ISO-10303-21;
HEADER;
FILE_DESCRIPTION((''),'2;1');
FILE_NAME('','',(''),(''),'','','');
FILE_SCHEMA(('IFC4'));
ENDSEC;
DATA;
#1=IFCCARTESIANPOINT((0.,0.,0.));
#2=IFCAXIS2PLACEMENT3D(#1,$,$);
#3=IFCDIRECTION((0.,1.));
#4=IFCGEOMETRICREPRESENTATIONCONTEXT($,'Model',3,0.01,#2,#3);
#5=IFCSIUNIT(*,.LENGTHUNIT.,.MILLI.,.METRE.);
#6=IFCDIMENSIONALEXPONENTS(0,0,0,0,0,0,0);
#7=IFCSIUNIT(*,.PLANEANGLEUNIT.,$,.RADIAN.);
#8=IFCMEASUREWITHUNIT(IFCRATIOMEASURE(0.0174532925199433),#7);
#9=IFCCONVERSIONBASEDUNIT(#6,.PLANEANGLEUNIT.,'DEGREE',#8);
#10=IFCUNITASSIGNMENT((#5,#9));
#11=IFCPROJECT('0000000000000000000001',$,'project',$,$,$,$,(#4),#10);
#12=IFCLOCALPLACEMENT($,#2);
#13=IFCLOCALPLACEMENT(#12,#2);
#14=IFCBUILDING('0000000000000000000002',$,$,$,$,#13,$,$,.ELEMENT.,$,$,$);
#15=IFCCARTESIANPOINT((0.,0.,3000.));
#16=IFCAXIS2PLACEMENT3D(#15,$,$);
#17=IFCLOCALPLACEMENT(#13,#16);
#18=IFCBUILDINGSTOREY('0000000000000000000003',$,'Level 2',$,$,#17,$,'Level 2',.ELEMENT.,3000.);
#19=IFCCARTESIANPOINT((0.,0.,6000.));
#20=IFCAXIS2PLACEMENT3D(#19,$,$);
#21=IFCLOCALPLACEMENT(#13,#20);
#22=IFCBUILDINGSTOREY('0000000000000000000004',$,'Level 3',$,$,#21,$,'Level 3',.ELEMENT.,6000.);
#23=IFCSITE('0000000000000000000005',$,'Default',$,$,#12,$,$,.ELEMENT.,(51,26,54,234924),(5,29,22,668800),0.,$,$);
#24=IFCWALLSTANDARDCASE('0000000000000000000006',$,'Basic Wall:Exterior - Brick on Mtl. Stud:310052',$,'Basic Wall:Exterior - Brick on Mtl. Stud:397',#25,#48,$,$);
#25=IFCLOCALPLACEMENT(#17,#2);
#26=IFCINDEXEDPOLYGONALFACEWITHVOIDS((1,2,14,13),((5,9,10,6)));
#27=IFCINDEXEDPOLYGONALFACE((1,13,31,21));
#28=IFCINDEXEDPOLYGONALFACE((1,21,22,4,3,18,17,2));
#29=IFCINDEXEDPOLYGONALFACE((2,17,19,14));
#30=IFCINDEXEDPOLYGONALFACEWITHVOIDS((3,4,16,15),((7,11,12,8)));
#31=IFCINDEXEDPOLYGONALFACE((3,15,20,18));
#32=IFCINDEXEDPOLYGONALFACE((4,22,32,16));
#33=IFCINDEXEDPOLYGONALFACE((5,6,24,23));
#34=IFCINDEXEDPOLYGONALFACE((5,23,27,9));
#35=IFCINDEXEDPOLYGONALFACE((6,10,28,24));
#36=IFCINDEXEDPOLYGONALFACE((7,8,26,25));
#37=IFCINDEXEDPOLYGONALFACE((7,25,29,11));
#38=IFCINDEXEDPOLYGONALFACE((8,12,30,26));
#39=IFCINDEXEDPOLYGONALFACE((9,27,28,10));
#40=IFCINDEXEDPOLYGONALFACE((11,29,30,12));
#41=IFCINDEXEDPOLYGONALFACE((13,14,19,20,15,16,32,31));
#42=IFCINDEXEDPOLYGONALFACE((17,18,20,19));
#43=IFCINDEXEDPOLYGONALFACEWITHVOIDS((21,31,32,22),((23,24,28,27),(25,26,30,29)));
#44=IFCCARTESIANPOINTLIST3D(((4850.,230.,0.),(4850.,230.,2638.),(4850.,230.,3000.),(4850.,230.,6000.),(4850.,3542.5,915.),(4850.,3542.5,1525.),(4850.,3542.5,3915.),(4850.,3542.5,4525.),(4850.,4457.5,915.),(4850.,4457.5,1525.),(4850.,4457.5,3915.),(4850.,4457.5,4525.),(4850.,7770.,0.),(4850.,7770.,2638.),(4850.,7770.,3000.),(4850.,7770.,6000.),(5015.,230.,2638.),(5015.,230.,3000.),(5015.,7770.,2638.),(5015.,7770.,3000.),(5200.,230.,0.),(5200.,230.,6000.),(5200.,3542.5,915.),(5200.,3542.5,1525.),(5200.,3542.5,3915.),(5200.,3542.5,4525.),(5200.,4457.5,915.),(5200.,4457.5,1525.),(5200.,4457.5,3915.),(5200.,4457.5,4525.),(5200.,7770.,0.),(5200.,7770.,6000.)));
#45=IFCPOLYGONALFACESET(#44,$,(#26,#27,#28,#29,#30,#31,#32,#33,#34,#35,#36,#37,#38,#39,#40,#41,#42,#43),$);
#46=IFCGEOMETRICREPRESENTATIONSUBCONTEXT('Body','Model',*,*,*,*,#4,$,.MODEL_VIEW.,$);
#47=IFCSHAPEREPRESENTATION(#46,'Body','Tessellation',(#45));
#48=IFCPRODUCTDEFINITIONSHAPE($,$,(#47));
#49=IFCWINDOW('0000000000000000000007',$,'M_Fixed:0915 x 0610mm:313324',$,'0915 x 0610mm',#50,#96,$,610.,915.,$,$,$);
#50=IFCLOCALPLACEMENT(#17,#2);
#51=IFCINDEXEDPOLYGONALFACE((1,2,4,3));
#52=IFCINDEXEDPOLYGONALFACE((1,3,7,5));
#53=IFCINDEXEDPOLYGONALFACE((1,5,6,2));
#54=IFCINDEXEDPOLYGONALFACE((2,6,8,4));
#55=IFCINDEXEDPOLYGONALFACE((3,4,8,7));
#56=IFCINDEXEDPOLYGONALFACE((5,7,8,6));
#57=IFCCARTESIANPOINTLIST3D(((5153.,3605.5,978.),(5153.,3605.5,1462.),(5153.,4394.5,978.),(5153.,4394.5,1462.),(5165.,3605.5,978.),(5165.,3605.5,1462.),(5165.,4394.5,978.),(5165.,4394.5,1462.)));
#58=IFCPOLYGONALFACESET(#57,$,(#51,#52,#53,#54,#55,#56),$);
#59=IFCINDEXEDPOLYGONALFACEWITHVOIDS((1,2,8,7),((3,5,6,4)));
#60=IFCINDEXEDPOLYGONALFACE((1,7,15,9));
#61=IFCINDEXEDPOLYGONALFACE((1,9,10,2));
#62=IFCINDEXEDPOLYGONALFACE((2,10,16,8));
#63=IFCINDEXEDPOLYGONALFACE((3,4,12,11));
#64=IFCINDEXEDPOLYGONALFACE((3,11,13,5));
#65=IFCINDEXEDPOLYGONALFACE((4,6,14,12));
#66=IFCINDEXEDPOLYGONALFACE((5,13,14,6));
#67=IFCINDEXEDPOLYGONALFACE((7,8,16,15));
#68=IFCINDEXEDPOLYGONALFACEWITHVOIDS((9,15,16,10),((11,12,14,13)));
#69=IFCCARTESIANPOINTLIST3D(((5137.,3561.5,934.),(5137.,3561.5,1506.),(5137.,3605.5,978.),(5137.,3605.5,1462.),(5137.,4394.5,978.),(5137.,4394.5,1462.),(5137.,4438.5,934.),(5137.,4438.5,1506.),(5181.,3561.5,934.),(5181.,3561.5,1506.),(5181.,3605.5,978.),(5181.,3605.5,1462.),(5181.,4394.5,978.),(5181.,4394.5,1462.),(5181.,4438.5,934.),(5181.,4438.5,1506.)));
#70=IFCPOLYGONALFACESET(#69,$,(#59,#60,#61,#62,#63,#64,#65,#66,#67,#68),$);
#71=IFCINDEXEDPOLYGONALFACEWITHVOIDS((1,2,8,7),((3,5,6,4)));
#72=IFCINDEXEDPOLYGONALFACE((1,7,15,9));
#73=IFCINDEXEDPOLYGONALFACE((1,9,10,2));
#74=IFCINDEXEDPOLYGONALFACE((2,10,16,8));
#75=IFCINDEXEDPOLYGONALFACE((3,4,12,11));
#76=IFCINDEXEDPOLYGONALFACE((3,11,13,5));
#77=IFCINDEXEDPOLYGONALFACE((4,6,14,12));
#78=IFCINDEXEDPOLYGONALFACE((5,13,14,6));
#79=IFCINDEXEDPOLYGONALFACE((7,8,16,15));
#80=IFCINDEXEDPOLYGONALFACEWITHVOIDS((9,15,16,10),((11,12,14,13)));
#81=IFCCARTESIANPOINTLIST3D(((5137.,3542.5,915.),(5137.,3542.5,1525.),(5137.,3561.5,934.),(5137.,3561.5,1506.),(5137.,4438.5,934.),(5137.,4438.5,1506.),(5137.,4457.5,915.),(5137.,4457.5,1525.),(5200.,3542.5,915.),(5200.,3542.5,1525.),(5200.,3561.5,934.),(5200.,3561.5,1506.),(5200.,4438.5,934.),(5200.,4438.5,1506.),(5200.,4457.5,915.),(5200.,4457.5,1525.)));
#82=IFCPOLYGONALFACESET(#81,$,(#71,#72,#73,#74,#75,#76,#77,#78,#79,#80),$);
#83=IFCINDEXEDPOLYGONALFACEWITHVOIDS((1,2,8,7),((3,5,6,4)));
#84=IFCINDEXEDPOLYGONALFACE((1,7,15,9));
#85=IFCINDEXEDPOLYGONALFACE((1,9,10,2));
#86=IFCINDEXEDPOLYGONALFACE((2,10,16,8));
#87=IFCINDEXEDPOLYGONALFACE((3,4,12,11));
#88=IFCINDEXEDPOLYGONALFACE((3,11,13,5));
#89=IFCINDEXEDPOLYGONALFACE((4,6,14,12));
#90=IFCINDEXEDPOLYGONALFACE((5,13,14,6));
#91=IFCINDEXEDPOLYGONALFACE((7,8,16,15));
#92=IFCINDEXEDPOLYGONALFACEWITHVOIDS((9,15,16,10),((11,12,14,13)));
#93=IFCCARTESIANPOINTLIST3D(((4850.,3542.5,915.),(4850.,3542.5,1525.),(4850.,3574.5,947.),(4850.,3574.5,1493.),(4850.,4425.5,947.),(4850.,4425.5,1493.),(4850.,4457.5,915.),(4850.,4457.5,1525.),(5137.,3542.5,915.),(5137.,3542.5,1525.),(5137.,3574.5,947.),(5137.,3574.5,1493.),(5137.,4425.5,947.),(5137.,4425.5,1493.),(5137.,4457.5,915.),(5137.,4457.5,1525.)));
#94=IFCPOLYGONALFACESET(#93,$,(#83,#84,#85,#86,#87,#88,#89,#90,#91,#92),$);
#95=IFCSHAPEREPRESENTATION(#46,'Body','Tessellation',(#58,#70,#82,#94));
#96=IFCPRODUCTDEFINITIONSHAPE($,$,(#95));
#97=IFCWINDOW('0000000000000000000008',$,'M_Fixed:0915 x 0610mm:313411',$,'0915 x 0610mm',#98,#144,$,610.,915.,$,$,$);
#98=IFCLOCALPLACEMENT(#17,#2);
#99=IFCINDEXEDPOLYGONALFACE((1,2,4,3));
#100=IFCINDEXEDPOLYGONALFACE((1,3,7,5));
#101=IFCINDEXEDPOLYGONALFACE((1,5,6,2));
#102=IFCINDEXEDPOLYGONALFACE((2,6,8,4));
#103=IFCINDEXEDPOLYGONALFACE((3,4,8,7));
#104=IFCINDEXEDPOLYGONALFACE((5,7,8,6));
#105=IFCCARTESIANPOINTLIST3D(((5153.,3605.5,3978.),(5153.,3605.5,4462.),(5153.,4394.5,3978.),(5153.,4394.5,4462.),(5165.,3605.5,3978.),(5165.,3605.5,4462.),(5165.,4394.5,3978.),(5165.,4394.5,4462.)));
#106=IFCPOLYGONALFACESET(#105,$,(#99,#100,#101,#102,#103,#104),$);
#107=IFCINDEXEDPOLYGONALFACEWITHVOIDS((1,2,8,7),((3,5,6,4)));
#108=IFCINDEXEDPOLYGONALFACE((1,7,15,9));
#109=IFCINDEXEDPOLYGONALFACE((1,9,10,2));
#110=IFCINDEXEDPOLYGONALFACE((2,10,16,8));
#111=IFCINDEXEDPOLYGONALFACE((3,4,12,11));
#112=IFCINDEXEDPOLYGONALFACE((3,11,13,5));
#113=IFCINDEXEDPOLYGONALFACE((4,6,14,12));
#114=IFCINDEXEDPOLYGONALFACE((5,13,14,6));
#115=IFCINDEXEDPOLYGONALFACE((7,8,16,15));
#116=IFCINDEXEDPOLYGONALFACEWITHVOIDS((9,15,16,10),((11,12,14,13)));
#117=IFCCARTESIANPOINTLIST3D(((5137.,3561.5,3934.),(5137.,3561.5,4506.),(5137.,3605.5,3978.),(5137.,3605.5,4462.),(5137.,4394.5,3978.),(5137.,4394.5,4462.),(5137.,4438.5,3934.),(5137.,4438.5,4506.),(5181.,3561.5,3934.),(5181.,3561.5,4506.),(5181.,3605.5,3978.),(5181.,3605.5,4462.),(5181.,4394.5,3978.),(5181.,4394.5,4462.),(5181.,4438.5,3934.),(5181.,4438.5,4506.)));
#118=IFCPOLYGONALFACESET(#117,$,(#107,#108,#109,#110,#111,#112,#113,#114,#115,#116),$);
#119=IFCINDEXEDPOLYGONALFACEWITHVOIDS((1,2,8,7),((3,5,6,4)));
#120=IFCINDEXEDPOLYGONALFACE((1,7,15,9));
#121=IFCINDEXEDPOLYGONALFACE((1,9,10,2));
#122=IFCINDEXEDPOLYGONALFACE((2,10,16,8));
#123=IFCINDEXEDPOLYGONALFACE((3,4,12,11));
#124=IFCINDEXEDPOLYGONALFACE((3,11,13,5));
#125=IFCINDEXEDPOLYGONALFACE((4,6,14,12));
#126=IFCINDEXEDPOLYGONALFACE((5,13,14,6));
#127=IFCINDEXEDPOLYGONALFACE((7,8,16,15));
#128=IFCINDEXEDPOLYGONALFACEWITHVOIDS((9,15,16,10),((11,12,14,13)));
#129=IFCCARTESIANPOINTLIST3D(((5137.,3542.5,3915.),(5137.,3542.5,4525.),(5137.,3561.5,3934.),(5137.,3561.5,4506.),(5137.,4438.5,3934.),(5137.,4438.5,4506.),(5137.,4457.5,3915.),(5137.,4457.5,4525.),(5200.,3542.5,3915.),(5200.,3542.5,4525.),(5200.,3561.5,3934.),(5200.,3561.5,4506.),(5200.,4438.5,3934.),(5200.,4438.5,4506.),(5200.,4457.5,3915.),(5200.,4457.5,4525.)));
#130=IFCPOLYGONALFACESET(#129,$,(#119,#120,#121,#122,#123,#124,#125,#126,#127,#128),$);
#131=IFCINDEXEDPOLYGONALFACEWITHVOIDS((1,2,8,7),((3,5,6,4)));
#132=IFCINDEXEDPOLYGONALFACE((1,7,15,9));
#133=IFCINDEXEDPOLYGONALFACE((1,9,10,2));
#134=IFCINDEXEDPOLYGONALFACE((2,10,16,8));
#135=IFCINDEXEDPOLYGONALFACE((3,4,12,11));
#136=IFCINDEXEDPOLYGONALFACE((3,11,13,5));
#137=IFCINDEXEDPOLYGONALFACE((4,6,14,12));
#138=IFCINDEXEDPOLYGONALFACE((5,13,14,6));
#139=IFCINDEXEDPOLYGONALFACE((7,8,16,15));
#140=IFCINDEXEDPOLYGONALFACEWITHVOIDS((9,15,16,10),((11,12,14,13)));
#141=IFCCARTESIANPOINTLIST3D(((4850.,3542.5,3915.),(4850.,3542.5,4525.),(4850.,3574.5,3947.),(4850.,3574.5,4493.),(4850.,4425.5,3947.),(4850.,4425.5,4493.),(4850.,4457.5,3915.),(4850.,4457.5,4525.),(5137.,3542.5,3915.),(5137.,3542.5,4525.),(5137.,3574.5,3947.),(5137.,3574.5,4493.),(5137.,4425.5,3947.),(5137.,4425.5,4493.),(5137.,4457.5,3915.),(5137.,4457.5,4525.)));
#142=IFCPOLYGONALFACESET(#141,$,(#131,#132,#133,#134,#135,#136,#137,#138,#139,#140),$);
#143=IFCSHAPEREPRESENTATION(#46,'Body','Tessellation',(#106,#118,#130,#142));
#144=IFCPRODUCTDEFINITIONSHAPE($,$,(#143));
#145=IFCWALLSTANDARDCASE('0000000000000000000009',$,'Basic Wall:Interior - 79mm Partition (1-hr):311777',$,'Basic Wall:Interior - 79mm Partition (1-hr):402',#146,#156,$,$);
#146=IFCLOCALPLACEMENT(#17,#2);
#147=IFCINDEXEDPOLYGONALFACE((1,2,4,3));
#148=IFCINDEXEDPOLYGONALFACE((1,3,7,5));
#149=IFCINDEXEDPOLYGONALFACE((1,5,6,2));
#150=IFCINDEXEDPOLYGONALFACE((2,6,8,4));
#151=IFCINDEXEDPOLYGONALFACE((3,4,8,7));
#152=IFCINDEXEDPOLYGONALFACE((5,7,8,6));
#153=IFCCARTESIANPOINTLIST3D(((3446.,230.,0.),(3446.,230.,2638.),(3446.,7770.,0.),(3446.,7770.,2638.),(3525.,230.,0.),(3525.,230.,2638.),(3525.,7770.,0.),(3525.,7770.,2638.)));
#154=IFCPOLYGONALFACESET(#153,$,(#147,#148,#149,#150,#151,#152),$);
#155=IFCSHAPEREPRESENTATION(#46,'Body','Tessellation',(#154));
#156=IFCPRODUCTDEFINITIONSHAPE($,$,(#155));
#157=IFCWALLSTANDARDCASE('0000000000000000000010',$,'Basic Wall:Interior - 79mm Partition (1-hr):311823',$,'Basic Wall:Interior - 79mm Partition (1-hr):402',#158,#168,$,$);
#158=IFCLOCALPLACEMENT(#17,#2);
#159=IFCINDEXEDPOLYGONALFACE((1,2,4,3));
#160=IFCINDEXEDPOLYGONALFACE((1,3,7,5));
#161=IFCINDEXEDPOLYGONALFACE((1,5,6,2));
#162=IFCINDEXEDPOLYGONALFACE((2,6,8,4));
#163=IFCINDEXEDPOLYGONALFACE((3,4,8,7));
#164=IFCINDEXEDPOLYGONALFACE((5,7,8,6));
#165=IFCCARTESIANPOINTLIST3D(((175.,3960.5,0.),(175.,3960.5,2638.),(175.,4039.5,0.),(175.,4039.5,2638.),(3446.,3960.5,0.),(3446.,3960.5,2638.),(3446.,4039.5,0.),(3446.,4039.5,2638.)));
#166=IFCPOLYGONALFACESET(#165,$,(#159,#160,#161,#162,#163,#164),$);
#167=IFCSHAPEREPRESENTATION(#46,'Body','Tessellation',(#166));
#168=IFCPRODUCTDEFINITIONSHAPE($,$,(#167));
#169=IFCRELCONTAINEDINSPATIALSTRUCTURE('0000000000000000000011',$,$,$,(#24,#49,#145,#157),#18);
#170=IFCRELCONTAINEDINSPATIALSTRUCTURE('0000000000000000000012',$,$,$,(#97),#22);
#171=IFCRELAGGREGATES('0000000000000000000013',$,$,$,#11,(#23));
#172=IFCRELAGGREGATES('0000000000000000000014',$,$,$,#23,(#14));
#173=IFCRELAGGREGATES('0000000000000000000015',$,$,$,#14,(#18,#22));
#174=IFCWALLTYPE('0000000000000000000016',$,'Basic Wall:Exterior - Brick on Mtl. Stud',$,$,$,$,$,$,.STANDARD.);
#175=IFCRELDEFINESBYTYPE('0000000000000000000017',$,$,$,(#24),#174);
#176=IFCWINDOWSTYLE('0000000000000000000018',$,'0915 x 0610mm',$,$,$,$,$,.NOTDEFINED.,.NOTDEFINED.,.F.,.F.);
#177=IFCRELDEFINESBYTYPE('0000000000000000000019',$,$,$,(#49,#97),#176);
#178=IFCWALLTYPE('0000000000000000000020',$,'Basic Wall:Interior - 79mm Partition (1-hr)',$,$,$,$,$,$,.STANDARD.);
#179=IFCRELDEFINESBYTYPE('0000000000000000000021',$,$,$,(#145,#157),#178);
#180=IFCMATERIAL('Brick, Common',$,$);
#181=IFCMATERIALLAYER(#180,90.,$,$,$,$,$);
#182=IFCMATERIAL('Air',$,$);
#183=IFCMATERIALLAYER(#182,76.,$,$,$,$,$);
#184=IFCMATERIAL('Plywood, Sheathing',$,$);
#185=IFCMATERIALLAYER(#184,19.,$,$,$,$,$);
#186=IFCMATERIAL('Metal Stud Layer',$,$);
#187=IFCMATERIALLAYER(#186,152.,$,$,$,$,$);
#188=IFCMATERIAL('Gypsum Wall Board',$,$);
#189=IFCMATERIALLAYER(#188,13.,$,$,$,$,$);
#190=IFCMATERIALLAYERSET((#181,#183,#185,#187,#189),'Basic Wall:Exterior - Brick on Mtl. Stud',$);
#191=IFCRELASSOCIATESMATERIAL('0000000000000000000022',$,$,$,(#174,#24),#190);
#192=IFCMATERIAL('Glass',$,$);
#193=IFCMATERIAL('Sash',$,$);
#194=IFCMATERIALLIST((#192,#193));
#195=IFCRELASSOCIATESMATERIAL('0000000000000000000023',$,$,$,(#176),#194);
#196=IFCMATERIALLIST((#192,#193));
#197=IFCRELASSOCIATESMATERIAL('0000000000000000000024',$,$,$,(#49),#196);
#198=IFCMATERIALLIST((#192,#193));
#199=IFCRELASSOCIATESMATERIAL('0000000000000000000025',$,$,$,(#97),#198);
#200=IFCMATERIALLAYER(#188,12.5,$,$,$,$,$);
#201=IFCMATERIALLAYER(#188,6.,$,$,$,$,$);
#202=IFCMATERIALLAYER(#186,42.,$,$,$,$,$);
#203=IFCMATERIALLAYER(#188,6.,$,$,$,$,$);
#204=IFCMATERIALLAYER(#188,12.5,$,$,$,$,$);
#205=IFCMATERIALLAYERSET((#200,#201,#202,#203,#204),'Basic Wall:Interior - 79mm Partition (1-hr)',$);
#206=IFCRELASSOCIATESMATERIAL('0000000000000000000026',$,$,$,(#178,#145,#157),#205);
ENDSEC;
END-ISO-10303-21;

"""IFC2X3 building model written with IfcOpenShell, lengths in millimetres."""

from ifc_helpers import new_model, entity, si_unit, converted_unit, direction, frame, frame_2d, origin, place, context, subcontext, project, spatial, polyline, rectangle, outline, extrude, clip, bounded_halfspace, source, transform, mapped, material, material_list, layer, layer_set, layer_usage, type_object, type_shapes, element, fill, save


model = new_model("IFC2X3")

# Units and contexts
model_context = context("Model", 3, precision=0.01, world=origin(), true_north=direction((0.0, 1.0)))
body_context = subcontext(model_context, "Body", "Model", "MODEL_VIEW")
ifc_project = project(units=[si_unit("LENGTHUNIT", "METRE", prefix="MILLI"), converted_unit("PLANEANGLEUNIT", "DEGREE", entity("IfcRatioMeasure", 0.0174532925199433), si_unit("PLANEANGLEUNIT", "RADIAN"), dimensions=[0, 0, 0, 0, 0, 0, 0])], contexts=[model_context])

# Site, building, storey
site_placement = place(None, origin())
site = spatial("IfcSite", under=ifc_project, at=site_placement, Name="Default", CompositionType="ELEMENT", RefLatitude=(51, 26, 54, 234924), RefLongitude=(5, 29, 22, 668800), RefElevation=0.0)
building_placement = place(site_placement, origin())
building = spatial("IfcBuilding", under=site, at=building_placement, CompositionType="ELEMENT")
storey_1_placement = place(building_placement, frame((0.0, 0.0, 3000.0)))
storey_1 = spatial("IfcBuildingStorey", under=building, at=storey_1_placement, Name="Level 2", LongName="Level 2", CompositionType="ELEMENT", Elevation=3000.0)

# Wall, openings, window
ifc_material_1 = material(Name="Brick, Common")
ifc_layer_1 = layer(ifc_material_1, 90.0)
ifc_material_2 = material(Name="Air")
ifc_layer_2 = layer(ifc_material_2, 76.0)
ifc_material_3 = material(Name="Plywood, Sheathing")
ifc_layer_3 = layer(ifc_material_3, 19.0)
ifc_material_4 = material(Name="Metal Stud Layer")
ifc_layer_4 = layer(ifc_material_4, 152.0)
ifc_material_5 = material(Name="Gypsum Wall Board")
ifc_layer_5 = layer(ifc_material_5, 13.0)
ifc_layer_set_1 = layer_set([ifc_layer_1, ifc_layer_2, ifc_layer_3, ifc_layer_4, ifc_layer_5], Name="Basic Wall:Exterior - Brick on Mtl. Stud")
ifc_layer_usage_1 = layer_usage(ifc_layer_set_1, "AXIS2", "NEGATIVE", 175.0)
wall_type_1 = type_object("IfcWallType", Name="Basic Wall:Exterior - Brick on Mtl. Stud", PredefinedType="STANDARD", material=ifc_layer_set_1)
wall_1_placement = place(storey_1_placement, frame((5025.0, 7770.0, 0.0), z_axis=(0.0, 0.0, 1.0), x_axis=(0.0, -1.0, 0.0)))
wall_1 = element("IfcWallStandardCase", 1, at=wall_1_placement, inside=storey_1, type_object=wall_type_1, material=ifc_layer_usage_1, Name="Basic Wall:Exterior - Brick on Mtl. Stud:310052", ObjectType="Basic Wall:Exterior - Brick on Mtl. Stud:397", context=body_context, shape_type="Clipping", body=[
    clip(extrude(rectangle(XDim=7540.0, YDim=350.0, at=frame_2d((3770.0, 0.0), x_axis=(-1.0, 0.0))), origin(), (0.0, 0.0, 1.0), 6000.0), bounded_halfspace(frame((0.0, -10.0, 2638.0), z_axis=(0.0, 1.0, 0.0), x_axis=(0.0, 0.0, 1.0)), True, frame((0.0, -10.0, 2638.0), z_axis=(0.0, 1.0, 0.0), x_axis=(0.0, 0.0, 1.0)), polyline([(0.0, 0.0), (362.0, 0.0), (362.0, 7540.0), (0.0, 7540.0), (0.0, 0.0)]))),
])
opening_1_placement = place(wall_1_placement, frame((3312.5, -175.0, 915.0)))
opening_1 = element("IfcOpeningElement", 2, at=opening_1_placement, cuts=wall_1, ObjectType="Opening", context=body_context, shape_type="SweptSolid", body=[
    extrude(rectangle(XDim=610.0, YDim=915.0, at=frame_2d((305.0, 457.5), x_axis=(1.0, 0.0))), frame((0.0, 0.0, 0.0), z_axis=(0.0, 1.0, 0.0), x_axis=(0.0, 0.0, 1.0)), (0.0, 0.0, 1.0), 350.0),
])
opening_2_placement = place(wall_1_placement, frame((3312.5, -175.0, 3915.0)))
opening_2 = element("IfcOpeningElement", 3, at=opening_2_placement, cuts=wall_1, ObjectType="Opening", context=body_context, shape_type="SweptSolid", body=[
    extrude(rectangle(XDim=610.0, YDim=915.0, at=frame_2d((305.0, 457.5), x_axis=(1.0, 0.0))), frame((0.0, 0.0, 0.0), z_axis=(0.0, 1.0, 0.0), x_axis=(0.0, 0.0, 1.0)), (0.0, 0.0, 1.0), 350.0),
])
ifc_material_6 = material(Name="Glass")
ifc_material_7 = material(Name="Sash")
ifc_material_list_1 = material_list([ifc_material_6, ifc_material_7])
ifc_material_list_2 = material_list([ifc_material_6, ifc_material_7])
window_style = type_object("IfcWindowStyle", Name="0915 x 0610mm", ConstructionType="NOTDEFINED", OperationType="NOTDEFINED", ParameterTakesPrecedence=False, Sizeable=False, material=ifc_material_list_2)
shared_shape = source(origin(), body_context, "Body", "SweptSolid", [
    extrude(rectangle(XDim=12.0, YDim=789.0, at=frame_2d((0.0, 0.0), x_axis=(1.0, 0.0))), frame((457.5, 309.0, 63.0), z_axis=(0.0, 0.0, 1.0), x_axis=(0.0, -1.0, 0.0)), (0.0, 0.0, 1.0), 484.0),
    extrude(outline(polyline([(-438.5, -286.0), (438.5, -286.0), (438.5, 286.0), (-438.5, 286.0), (-438.5, -286.0)]), holes=[polyline([(-394.5, -242.0), (-394.5, 242.0), (394.5, 242.0), (394.5, -242.0), (-394.5, -242.0)])]), frame((457.5, 287.0, 305.0), z_axis=(0.0, 1.0, 0.0), x_axis=(1.0, 0.0, 0.0)), (0.0, 0.0, 1.0), 44.0),
    extrude(outline(polyline([(-457.5, -305.0), (457.5, -305.0), (457.5, 305.0), (-457.5, 305.0), (-457.5, -305.0)]), holes=[polyline([(-438.5, -286.0), (-438.5, 286.0), (438.5, 286.0), (438.5, -286.0), (-438.5, -286.0)])]), frame((457.5, 287.0, 305.0), z_axis=(0.0, 1.0, 0.0), x_axis=(1.0, 0.0, 0.0)), (0.0, 0.0, 1.0), 63.0),
    extrude(outline(polyline([(-457.5, -305.0), (457.5, -305.0), (457.5, 305.0), (-457.5, 305.0), (-457.5, -305.0)]), holes=[polyline([(-425.5, -273.0), (-425.5, 273.0), (425.5, 273.0), (425.5, -273.0), (-425.5, -273.0)])]), frame((457.5, 0.0, 305.0), z_axis=(0.0, 1.0, 0.0), x_axis=(1.0, 0.0, 0.0)), (0.0, 0.0, 1.0), 287.0),
])
type_shapes(window_style, [shared_shape])
window_1_placement = place(opening_1_placement, origin())
window_1 = element("IfcWindow", 4, at=window_1_placement, inside=storey_1, type_object=window_style, material=ifc_material_list_1, Name="M_Fixed:0915 x 0610mm:313324", ObjectType="0915 x 0610mm", OverallHeight=610.0, OverallWidth=915.0, context=body_context, shape_type="MappedRepresentation", body=[
    mapped(shared_shape, transform((0.0, 0.0, 0.0), scale=1.0)),
])
fill(opening_1, window_1)

# Shared definitions
storey_2_placement = place(building_placement, frame((0.0, 0.0, 6000.0)))
storey_2 = spatial("IfcBuildingStorey", under=building, at=storey_2_placement, Name="Level 3", LongName="Level 3", CompositionType="ELEMENT", Elevation=6000.0)

# Window
ifc_material_list_3 = material_list([ifc_material_6, ifc_material_7])
window_2_placement = place(opening_2_placement, origin())
window_2 = element("IfcWindow", 5, at=window_2_placement, inside=storey_2, type_object=window_style, material=ifc_material_list_3, Name="M_Fixed:0915 x 0610mm:313411", ObjectType="0915 x 0610mm", OverallHeight=610.0, OverallWidth=915.0, context=body_context, shape_type="MappedRepresentation", body=[
    mapped(shared_shape, transform((0.0, 0.0, 0.0), scale=1.0)),
])
fill(opening_2, window_2)

# Walls
ifc_layer_6 = layer(ifc_material_5, 12.5)
ifc_layer_7 = layer(ifc_material_5, 6.0)
ifc_layer_8 = layer(ifc_material_4, 42.0)
ifc_layer_9 = layer(ifc_material_5, 6.0)
ifc_layer_10 = layer(ifc_material_5, 12.5)
ifc_layer_set_2 = layer_set([ifc_layer_6, ifc_layer_7, ifc_layer_8, ifc_layer_9, ifc_layer_10], Name="Basic Wall:Interior - 79mm Partition (1-hr)")
ifc_layer_usage_2 = layer_usage(ifc_layer_set_2, "AXIS2", "NEGATIVE", 39.5)
wall_type_2 = type_object("IfcWallType", Name="Basic Wall:Interior - 79mm Partition (1-hr)", PredefinedType="STANDARD", material=ifc_layer_set_2)
wall_2_placement = place(storey_1_placement, frame((3485.5, 7770.0, 0.0), z_axis=(0.0, 0.0, 1.0), x_axis=(0.0, -1.0, 0.0)))
element("IfcWallStandardCase", 6, at=wall_2_placement, inside=storey_1, type_object=wall_type_2, material=ifc_layer_usage_2, Name="Basic Wall:Interior - 79mm Partition (1-hr):311777", ObjectType="Basic Wall:Interior - 79mm Partition (1-hr):402", context=body_context, shape_type="Clipping", body=[
    clip(extrude(rectangle(XDim=7540.0, YDim=79.0, at=frame_2d((3770.0, 0.0), x_axis=(-1.0, 0.0))), origin(), (0.0, 0.0, 1.0), 2638.0), bounded_halfspace(frame((0.0, -39.5, 2638.0), z_axis=(0.0, 0.0, -1.0), x_axis=(1.0, 0.0, 0.0)), True, frame((0.0, -39.5, 2638.0)), polyline([(0.0, 0.0), (3730.5, 0.0), (3809.5, 0.0), (7540.0, 0.0), (7540.0, 79.0), (0.0, 79.0), (0.0, 0.0)]))),
])
ifc_layer_usage_3 = layer_usage(ifc_layer_set_2, "AXIS2", "NEGATIVE", 39.5)
wall_3_placement = place(storey_1_placement, frame((3446.0, 4000.0, 0.0), z_axis=(0.0, 0.0, 1.0), x_axis=(-1.0, 0.0, 0.0)))
element("IfcWallStandardCase", 7, at=wall_3_placement, inside=storey_1, type_object=wall_type_2, material=ifc_layer_usage_3, Name="Basic Wall:Interior - 79mm Partition (1-hr):311823", ObjectType="Basic Wall:Interior - 79mm Partition (1-hr):402", context=body_context, shape_type="Clipping", body=[
    clip(extrude(rectangle(XDim=3271.0, YDim=79.0, at=frame_2d((1635.5, 0.0), x_axis=(-1.0, 0.0))), origin(), (0.0, 0.0, 1.0), 2638.0), bounded_halfspace(frame((0.0, -39.5, 2638.0), z_axis=(0.0, 0.0, -1.0), x_axis=(0.0, 1.0, 0.0)), True, frame((0.0, -39.5, 2638.0)), polyline([(0.0, 0.0), (3271.0, 0.0), (3271.0, 79.0), (0.0, 79.0), (0.0, 0.0)]))),
])

save(model, "model.ifc")
